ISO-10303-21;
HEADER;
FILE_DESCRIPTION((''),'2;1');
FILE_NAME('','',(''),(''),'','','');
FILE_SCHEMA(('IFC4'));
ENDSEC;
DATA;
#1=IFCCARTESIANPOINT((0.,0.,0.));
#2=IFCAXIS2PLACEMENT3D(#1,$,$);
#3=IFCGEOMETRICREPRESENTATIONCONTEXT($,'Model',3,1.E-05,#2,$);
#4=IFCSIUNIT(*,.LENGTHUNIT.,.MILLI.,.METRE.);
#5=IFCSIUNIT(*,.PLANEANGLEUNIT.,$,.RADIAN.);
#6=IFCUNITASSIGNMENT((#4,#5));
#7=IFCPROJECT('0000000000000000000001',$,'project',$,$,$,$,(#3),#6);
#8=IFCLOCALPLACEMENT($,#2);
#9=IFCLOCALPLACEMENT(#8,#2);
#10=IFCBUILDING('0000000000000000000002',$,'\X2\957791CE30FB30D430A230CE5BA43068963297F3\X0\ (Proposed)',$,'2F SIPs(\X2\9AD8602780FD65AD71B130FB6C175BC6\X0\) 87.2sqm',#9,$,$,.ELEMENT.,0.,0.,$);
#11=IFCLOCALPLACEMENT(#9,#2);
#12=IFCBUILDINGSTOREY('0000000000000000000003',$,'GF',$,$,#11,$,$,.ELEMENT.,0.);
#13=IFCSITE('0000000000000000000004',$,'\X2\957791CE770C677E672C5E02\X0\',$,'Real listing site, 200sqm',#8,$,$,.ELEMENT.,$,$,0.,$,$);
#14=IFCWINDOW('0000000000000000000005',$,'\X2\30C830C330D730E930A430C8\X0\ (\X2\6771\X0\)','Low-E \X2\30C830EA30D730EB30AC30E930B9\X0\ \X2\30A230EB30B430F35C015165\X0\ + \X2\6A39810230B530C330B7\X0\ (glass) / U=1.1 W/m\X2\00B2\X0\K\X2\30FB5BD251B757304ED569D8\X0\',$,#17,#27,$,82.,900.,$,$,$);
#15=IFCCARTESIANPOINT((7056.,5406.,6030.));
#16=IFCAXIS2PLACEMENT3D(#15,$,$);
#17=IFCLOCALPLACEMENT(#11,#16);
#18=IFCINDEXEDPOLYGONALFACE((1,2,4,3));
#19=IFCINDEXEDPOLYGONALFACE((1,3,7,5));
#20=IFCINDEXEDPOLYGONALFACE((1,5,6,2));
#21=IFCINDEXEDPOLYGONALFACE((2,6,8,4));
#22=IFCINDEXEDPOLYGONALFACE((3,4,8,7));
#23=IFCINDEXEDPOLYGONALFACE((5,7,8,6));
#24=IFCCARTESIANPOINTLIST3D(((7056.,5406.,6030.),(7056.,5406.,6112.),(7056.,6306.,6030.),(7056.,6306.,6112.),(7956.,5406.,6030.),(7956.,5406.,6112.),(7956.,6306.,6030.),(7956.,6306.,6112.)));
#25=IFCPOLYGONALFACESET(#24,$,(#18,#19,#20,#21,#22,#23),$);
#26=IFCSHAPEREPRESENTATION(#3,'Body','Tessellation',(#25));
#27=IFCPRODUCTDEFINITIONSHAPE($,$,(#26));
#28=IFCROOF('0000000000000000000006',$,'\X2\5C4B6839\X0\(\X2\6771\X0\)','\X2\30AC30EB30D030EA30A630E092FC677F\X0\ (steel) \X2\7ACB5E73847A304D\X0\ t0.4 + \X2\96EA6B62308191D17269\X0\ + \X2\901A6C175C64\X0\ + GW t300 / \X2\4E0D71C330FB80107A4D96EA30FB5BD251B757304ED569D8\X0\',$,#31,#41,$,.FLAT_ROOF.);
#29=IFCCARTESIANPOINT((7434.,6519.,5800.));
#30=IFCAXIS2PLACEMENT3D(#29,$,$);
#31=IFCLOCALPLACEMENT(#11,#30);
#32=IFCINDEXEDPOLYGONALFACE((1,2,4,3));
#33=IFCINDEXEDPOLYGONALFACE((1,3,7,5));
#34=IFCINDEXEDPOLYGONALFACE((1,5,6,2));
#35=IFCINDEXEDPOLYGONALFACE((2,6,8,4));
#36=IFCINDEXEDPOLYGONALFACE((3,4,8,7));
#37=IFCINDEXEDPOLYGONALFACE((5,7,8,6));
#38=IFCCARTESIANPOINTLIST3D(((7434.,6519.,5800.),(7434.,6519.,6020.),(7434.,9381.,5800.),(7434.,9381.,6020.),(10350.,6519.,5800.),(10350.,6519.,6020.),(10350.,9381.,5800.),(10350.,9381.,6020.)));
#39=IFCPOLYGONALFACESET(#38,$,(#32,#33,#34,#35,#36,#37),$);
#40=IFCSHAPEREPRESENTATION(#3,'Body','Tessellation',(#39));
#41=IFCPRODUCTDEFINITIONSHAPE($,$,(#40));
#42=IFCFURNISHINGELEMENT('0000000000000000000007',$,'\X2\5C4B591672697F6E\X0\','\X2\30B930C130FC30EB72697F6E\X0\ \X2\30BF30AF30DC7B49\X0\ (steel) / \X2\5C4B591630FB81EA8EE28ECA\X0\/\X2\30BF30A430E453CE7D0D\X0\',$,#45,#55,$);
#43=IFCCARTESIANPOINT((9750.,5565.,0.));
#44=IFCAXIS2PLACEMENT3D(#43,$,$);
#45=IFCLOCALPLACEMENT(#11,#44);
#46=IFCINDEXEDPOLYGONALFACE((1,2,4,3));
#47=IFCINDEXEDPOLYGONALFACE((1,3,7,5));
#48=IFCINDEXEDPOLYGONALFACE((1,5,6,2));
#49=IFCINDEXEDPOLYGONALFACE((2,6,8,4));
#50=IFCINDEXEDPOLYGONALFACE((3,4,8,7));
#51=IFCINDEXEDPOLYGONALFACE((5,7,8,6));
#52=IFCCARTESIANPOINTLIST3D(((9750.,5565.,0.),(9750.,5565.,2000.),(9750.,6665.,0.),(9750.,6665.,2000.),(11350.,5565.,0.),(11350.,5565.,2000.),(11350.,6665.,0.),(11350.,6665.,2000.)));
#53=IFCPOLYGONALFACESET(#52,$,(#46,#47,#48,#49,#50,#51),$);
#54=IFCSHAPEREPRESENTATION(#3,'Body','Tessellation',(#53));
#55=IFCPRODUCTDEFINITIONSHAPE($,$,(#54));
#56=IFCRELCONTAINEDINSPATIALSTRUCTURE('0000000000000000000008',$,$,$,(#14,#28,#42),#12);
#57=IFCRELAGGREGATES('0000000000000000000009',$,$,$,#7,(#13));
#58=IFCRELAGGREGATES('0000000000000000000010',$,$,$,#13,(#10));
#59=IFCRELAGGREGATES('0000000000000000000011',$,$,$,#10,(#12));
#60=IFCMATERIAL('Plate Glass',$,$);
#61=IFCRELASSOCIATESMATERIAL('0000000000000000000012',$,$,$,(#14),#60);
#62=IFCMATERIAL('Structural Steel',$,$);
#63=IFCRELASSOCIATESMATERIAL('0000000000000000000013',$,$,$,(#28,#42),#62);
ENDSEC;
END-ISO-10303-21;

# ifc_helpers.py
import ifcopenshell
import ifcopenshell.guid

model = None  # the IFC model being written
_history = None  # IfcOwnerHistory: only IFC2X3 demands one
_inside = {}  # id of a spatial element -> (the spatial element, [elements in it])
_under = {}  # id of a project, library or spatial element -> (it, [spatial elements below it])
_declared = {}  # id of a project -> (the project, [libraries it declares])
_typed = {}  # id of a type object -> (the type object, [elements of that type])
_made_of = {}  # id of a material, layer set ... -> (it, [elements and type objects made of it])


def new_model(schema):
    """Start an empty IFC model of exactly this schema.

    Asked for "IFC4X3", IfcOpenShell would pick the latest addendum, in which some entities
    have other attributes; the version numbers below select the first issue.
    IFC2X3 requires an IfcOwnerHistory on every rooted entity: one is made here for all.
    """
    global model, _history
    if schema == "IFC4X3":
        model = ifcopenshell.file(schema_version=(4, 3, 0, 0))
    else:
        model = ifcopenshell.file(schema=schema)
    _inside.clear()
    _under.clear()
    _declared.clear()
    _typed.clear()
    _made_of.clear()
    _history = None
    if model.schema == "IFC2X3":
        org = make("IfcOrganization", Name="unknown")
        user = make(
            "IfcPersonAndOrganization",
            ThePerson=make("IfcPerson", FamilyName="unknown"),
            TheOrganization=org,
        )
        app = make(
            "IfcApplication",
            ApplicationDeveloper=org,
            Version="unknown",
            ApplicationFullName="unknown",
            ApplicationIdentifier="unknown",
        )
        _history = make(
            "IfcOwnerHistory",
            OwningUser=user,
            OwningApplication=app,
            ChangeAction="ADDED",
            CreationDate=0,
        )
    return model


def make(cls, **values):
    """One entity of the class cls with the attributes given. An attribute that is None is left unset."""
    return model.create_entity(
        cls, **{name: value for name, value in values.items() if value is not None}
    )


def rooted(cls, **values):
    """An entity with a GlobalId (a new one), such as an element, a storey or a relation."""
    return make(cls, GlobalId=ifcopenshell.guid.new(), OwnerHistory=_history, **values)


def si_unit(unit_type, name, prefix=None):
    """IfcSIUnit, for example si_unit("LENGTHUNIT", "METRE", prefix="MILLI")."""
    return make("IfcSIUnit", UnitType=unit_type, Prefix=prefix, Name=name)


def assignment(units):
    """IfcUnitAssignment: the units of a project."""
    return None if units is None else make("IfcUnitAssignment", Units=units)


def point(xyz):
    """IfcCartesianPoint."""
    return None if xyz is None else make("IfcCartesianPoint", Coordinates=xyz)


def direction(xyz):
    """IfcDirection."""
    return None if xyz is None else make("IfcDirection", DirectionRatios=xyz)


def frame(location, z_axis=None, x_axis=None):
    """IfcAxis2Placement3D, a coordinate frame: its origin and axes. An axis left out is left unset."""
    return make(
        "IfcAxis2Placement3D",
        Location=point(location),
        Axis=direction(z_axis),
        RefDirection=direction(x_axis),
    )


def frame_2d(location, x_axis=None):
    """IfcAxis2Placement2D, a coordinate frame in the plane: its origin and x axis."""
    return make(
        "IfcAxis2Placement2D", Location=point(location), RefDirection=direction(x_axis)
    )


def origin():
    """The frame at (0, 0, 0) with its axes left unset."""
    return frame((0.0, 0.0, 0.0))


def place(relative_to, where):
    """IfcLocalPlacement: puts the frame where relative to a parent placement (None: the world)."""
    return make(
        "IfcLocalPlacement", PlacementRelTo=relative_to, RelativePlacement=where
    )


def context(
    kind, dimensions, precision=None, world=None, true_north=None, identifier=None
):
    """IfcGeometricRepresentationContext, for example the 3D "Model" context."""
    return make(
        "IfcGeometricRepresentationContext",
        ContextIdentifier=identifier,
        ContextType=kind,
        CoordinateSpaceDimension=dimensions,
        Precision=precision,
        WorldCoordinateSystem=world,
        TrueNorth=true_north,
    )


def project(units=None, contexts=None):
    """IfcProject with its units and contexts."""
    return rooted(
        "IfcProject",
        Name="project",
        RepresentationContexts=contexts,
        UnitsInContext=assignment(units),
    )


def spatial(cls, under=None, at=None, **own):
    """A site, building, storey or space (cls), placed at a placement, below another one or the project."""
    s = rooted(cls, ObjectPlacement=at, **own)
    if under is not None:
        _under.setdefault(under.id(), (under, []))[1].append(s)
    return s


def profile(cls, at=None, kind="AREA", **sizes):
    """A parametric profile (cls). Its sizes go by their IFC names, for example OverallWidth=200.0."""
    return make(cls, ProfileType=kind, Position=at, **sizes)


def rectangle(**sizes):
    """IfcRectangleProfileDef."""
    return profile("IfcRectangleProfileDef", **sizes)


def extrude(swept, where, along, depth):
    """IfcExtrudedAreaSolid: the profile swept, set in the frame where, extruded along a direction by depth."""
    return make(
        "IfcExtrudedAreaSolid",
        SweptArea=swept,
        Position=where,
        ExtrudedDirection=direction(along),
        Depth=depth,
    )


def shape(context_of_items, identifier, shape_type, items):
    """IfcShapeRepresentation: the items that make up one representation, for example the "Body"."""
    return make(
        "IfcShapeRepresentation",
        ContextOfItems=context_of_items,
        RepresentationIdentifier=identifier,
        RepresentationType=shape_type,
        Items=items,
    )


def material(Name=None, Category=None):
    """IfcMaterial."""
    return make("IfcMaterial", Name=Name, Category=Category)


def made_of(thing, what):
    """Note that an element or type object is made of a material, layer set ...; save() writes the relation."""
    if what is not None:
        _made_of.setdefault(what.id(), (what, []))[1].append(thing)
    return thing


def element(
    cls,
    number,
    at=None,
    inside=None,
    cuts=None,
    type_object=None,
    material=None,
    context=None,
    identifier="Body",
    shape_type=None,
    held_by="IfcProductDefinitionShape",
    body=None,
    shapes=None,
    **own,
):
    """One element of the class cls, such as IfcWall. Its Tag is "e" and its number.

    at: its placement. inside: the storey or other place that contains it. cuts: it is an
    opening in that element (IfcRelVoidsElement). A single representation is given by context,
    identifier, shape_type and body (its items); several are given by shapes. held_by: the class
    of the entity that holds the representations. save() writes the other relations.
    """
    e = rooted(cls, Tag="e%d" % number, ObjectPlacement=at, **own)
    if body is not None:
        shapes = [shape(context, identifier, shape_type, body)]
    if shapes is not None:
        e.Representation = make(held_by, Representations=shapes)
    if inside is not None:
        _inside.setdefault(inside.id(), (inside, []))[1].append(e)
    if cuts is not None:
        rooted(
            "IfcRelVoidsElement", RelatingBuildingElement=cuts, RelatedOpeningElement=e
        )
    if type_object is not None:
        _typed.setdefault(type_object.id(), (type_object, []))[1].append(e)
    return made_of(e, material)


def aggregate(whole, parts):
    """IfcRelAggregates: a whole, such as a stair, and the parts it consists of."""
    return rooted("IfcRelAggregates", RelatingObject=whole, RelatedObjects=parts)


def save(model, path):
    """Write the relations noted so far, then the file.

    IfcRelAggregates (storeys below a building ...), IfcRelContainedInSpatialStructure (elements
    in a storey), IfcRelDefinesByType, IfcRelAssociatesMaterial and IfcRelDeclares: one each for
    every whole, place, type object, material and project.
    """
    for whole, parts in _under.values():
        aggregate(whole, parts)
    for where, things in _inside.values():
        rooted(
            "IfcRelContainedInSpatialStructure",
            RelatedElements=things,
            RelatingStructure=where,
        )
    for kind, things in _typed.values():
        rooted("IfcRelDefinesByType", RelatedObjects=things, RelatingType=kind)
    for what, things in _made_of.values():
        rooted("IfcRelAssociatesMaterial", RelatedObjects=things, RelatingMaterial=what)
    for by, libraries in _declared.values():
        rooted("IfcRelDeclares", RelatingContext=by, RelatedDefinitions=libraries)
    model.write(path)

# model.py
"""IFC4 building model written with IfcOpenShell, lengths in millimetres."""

from ifc_helpers import new_model, si_unit, frame, frame_2d, origin, place, context, project, spatial, rectangle, extrude, material, element, save


model = new_model("IFC4")

# Units and contexts
model_context = context("Model", 3, precision=1e-05, world=origin())
ifc_project = project(units=[si_unit("LENGTHUNIT", "METRE", prefix="MILLI"), si_unit("PLANEANGLEUNIT", "RADIAN")], contexts=[model_context])

# Site, building, storey
site_placement = place(None, origin())
site = spatial("IfcSite", under=ifc_project, at=site_placement, Name="長野県松本市", ObjectType="Real listing site, 200sqm", CompositionType="ELEMENT", RefElevation=0.0)
building_placement = place(site_placement, origin())
building = spatial("IfcBuilding", under=site, at=building_placement, Name="長野・ピアノ室と防音 (Proposed)", ObjectType="2F SIPs(高性能断熱・気密) 87.2sqm", CompositionType="ELEMENT", ElevationOfRefHeight=0.0, ElevationOfTerrain=0.0)
storey_placement = place(building_placement, origin())
storey = spatial("IfcBuildingStorey", under=building, at=storey_placement, Name="GF", CompositionType="ELEMENT", Elevation=0.0)

# Shared definitions
ifc_material_1 = material(Name="Plate Glass")

# Window
window_1_placement = place(storey_placement, frame((7056.0, 5406.0, 6030.0)))
element("IfcWindow", 1, at=window_1_placement, inside=storey, material=ifc_material_1, Name="トップライト (東)", Description="Low-E トリプルガラス アルゴン封入 + 樹脂サッシ (glass) / U=1.1 W/m²K・寒冷地仕様", OverallHeight=82.0, OverallWidth=900.0, context=model_context, shape_type="SweptSolid", body=[
    extrude(rectangle(XDim=900.0, YDim=900.0, at=frame_2d((450.0, 450.0))), frame((7056.0, 5406.0, 6030.0)), (0.0, 0.0, 1.0), 82.0),
])

# Roof
ifc_material_2 = material(Name="Structural Steel")
for number, where, name in (
    (2, (7434.0, 6519.0, 5800.0), "屋根(東)"),
):
    element("IfcRoof", number, at=place(storey_placement, frame(where)), inside=storey, material=ifc_material_2, Name=name, Description="ガルバリウム鋼板 (steel) 立平葺き t0.4 + 雪止め金物 + 通気層 + GW t300 / 不燃・耐積雪・寒冷地仕様", PredefinedType="FLAT_ROOF", context=model_context, shape_type="SweptSolid", body=[
        extrude(rectangle(XDim=2916.0, YDim=2862.0, at=frame_2d((1458.0, 1431.0))), frame((7434.0, 6519.0, 5800.0)), (0.0, 0.0, 1.0), 220.0),
    ])

# Furnishing element
furnishing_placement = place(storey_placement, frame((9750.0, 5565.0, 0.0)))
element("IfcFurnishingElement", 3, at=furnishing_placement, inside=storey, material=ifc_material_2, Name="屋外物置", Description="スチール物置 タクボ等 (steel) / 屋外・自転車/タイヤ収納", context=model_context, shape_type="SweptSolid", body=[
    extrude(rectangle(XDim=1600.0, YDim=1100.0, at=frame_2d((800.0, 550.0))), frame((9750.0, 5565.0, 0.0)), (0.0, 0.0, 1.0), 2000.0),
])

save(model, "model.ifc")
